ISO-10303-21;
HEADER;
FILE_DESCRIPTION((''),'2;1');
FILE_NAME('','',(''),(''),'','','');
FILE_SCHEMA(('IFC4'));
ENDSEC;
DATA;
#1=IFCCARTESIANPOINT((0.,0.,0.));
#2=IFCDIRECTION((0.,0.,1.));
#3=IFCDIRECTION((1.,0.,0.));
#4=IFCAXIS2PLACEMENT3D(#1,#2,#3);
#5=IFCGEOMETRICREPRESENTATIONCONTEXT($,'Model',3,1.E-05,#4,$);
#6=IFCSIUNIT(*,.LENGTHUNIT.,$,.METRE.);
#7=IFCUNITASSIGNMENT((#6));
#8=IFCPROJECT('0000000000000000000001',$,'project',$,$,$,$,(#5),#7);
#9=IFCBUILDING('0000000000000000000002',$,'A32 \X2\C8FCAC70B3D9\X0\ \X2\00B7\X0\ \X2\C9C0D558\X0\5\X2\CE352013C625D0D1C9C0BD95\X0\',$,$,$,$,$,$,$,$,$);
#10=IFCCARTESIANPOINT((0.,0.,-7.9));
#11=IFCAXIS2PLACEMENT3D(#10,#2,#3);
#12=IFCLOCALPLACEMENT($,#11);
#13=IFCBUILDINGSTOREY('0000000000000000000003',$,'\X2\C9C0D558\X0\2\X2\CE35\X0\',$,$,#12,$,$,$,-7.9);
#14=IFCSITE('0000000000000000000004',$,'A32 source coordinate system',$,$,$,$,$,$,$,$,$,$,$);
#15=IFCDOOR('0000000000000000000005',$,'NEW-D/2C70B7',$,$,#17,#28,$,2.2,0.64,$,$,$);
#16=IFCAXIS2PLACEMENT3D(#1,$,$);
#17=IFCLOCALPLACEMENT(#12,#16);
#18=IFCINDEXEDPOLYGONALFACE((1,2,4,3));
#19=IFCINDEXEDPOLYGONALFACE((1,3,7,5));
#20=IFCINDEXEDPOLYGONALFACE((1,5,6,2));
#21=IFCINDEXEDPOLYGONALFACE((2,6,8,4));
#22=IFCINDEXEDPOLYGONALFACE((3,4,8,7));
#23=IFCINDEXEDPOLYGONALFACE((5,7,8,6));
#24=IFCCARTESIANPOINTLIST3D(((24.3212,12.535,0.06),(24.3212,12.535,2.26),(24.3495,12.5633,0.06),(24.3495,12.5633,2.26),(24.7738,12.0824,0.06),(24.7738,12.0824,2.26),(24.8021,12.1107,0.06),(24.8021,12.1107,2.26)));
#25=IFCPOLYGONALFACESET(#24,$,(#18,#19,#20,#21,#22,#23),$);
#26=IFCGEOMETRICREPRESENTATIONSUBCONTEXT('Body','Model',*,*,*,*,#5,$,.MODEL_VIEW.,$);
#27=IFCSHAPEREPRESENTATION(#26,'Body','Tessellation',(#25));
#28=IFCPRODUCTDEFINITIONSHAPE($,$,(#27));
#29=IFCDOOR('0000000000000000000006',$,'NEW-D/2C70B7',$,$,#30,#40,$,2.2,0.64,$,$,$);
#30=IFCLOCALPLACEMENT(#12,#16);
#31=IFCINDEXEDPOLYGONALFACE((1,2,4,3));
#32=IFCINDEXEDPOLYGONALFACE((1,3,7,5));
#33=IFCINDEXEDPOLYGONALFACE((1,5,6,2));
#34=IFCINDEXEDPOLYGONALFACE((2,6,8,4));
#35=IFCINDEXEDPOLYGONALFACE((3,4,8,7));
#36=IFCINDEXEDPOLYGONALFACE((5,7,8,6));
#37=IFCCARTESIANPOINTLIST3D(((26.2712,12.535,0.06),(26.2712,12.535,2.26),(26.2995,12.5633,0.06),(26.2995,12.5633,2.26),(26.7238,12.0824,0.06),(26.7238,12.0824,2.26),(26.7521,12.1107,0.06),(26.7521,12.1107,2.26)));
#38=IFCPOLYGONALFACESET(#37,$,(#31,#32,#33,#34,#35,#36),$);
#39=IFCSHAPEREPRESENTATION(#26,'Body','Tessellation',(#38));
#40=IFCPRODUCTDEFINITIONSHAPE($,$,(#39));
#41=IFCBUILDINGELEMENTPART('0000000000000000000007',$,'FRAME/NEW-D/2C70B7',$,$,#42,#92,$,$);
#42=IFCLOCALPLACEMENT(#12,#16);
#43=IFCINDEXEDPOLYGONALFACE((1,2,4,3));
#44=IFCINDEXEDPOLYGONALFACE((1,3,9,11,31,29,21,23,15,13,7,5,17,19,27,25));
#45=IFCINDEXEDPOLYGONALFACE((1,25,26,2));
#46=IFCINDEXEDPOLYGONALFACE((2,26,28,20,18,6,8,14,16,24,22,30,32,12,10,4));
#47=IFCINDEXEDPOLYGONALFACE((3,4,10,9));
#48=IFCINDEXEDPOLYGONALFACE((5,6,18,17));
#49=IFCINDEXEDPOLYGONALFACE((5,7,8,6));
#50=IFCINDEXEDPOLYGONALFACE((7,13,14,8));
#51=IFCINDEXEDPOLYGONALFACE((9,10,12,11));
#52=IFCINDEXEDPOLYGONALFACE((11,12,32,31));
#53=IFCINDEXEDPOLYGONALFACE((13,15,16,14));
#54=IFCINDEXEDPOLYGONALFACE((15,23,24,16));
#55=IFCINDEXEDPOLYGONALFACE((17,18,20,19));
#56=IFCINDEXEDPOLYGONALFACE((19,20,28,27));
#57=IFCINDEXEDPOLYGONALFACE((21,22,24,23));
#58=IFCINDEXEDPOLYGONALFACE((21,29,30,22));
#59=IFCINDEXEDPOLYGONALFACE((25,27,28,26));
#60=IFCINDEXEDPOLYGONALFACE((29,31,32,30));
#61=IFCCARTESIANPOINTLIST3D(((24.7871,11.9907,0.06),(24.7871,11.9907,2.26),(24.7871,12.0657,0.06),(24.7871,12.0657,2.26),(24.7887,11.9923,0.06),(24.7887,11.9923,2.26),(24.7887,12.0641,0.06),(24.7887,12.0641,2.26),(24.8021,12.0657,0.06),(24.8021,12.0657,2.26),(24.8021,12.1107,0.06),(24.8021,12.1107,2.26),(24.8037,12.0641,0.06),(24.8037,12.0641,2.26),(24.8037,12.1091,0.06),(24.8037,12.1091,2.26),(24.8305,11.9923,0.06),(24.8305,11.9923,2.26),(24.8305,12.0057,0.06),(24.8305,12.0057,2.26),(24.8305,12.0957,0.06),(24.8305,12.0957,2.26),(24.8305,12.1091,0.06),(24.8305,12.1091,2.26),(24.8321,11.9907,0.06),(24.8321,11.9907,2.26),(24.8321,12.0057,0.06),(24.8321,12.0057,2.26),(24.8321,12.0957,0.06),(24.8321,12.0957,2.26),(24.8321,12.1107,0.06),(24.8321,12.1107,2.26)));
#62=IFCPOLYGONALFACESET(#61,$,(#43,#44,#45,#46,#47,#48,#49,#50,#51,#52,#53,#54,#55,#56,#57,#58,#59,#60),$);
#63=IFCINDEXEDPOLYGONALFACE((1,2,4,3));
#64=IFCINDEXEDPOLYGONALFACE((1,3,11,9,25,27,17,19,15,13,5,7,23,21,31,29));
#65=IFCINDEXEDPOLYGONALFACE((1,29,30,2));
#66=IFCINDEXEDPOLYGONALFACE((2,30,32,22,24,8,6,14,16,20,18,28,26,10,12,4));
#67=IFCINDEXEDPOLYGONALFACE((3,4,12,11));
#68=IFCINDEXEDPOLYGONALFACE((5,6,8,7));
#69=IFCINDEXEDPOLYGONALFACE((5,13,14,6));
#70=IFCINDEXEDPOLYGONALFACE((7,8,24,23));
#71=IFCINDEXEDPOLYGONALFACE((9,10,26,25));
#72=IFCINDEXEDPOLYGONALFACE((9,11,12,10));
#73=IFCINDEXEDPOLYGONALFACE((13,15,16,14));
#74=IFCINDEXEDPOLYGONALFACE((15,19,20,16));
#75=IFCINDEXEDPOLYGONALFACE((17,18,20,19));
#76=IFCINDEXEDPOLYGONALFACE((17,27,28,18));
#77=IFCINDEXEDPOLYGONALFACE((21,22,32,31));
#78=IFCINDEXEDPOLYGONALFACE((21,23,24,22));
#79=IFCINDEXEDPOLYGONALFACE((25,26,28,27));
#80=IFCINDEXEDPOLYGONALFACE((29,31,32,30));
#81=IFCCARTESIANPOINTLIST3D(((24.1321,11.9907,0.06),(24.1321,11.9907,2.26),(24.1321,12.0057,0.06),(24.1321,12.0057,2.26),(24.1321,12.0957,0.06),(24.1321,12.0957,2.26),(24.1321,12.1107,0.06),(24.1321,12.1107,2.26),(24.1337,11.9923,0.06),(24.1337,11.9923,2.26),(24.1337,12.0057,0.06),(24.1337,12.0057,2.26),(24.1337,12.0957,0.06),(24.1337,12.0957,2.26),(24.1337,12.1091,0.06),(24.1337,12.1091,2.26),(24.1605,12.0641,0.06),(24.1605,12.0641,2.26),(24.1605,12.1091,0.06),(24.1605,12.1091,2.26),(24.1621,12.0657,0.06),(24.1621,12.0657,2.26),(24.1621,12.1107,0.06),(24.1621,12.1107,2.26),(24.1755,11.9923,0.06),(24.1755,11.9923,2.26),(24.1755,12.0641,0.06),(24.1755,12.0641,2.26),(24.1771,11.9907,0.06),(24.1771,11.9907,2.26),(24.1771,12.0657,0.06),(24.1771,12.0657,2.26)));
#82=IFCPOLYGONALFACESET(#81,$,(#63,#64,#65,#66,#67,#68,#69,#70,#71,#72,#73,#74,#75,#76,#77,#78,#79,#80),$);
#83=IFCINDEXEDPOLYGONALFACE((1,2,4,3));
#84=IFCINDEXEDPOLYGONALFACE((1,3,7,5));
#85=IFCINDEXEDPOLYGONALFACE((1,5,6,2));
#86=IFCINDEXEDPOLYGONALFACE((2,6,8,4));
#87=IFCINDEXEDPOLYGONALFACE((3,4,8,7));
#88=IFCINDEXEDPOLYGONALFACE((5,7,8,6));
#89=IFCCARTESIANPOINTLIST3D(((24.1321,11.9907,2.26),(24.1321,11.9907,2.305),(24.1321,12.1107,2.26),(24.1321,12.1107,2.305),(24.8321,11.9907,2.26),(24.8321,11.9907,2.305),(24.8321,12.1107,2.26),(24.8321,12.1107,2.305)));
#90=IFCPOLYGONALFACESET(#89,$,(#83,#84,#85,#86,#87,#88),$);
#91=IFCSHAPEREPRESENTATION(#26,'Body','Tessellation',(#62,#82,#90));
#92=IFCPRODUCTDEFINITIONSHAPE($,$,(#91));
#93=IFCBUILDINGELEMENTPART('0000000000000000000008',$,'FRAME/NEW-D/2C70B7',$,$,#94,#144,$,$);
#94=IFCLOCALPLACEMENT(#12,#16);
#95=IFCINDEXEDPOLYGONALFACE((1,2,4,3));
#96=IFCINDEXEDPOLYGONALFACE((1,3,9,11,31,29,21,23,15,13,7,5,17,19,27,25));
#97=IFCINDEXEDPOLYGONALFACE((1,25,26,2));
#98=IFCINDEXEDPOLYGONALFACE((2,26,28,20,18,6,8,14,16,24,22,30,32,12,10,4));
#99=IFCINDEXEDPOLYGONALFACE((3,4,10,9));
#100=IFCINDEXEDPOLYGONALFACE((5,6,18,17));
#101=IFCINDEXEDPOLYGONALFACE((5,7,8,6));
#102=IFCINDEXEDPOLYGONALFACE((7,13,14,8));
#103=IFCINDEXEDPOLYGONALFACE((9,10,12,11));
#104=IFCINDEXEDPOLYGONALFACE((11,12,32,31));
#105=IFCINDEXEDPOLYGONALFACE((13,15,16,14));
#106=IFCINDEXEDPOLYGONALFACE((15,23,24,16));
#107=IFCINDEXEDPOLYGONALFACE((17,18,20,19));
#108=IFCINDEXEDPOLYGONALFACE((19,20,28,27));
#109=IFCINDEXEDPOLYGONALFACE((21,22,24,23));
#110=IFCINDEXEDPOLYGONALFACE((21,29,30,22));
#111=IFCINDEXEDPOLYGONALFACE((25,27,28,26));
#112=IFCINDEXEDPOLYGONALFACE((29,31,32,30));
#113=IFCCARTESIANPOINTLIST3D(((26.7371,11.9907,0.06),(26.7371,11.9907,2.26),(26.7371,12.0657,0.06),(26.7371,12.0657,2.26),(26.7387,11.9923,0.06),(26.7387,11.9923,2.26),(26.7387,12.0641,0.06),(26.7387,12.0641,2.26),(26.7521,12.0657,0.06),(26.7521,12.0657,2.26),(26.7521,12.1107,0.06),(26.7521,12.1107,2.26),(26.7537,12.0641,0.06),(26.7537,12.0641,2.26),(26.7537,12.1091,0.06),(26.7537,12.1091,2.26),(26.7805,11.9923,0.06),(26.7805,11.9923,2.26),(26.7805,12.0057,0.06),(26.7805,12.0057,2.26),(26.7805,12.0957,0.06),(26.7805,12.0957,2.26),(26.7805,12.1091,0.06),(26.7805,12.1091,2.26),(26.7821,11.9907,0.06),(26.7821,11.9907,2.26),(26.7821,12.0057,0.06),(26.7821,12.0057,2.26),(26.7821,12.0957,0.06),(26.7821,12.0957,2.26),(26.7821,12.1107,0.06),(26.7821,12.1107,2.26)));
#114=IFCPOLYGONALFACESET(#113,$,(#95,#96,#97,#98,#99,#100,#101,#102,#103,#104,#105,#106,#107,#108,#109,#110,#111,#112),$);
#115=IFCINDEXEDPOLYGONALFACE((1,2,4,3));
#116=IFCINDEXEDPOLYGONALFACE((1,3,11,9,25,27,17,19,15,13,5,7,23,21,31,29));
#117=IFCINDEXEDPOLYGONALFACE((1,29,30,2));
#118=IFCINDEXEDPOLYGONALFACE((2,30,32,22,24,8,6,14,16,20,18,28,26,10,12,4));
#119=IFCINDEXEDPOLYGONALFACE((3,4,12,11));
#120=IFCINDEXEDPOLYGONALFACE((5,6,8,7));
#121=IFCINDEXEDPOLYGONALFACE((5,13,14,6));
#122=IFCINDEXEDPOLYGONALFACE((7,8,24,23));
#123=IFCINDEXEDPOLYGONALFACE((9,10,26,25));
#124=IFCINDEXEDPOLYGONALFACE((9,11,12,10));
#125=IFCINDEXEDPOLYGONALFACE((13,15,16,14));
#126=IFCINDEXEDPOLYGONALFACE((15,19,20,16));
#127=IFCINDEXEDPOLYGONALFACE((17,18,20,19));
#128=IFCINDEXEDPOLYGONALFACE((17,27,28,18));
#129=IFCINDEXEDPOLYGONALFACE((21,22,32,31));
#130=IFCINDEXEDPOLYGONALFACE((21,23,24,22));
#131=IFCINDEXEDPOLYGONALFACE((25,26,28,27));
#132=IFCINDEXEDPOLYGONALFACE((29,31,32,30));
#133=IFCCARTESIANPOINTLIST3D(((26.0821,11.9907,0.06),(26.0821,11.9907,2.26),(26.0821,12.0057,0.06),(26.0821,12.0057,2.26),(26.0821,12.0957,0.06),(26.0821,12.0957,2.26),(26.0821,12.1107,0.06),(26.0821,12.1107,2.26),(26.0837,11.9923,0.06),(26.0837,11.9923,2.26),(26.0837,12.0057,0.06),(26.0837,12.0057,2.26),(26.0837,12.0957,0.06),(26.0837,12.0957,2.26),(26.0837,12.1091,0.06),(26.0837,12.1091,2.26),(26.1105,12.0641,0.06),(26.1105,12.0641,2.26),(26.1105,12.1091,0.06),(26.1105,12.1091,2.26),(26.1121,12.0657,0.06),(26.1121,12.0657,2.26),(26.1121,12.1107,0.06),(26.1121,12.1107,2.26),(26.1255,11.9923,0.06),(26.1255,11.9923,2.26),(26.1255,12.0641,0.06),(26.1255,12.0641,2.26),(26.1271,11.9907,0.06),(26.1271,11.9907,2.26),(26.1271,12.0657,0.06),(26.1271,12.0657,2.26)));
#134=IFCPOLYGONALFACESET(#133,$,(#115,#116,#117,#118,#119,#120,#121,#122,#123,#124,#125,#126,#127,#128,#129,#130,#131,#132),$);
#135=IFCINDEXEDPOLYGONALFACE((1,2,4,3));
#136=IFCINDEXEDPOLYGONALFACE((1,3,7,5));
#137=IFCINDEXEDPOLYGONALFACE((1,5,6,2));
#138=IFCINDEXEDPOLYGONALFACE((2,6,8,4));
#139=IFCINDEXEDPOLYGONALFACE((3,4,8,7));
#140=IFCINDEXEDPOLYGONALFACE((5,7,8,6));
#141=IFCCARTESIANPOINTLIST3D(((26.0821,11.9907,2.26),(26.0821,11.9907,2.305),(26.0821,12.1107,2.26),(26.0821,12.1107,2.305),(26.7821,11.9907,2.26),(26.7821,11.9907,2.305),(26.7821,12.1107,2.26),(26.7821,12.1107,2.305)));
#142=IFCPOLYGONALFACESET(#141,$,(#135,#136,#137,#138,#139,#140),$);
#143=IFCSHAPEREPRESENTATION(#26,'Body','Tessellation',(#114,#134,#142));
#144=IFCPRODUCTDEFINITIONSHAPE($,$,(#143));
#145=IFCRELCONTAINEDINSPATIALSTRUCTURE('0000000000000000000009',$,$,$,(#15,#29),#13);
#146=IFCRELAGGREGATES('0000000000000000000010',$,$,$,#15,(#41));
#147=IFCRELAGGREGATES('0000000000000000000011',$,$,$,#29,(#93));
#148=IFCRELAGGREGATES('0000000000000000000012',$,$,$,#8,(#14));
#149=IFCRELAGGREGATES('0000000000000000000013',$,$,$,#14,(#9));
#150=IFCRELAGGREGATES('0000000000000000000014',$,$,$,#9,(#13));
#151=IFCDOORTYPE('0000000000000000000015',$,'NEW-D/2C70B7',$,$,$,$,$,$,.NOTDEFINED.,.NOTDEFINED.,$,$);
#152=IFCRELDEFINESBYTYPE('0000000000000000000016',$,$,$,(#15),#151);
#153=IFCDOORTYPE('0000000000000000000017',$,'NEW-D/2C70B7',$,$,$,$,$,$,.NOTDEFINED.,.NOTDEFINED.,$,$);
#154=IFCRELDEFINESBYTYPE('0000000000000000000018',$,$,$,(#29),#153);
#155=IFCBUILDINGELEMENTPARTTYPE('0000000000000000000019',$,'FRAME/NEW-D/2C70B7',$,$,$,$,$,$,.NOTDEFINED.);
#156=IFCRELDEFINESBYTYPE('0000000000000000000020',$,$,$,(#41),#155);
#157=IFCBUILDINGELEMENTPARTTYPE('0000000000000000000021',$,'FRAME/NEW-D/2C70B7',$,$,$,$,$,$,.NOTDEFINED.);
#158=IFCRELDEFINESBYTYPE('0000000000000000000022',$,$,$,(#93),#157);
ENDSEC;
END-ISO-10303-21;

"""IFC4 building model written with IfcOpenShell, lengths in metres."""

from ifc_helpers import new_model, si_unit, frame, origin, origin_with_axes, place, context, subcontext, project, spatial, polyline, outline, extrude, source, transform, mapped, type_object, type_shapes, element, aggregate, save


model = new_model("IFC4")

# Units and contexts
model_context = context("Model", 3, precision=1e-05, world=origin_with_axes())
body_context = subcontext(model_context, "Body", "Model", "MODEL_VIEW")
ifc_project = project(units=[si_unit("LENGTHUNIT", "METRE")], contexts=[model_context])

# Site, building, storey
site = spatial("IfcSite", under=ifc_project, Name="A32 source coordinate system")
building = spatial("IfcBuilding", under=site, Name="A32 주거동 · 지하5층–옥탑지붕")
storey_placement = place(None, frame((0.0, 0.0, -7.9), z_axis=(0.0, 0.0, 1.0), x_axis=(1.0, 0.0, 0.0)))
storey = spatial("IfcBuildingStorey", under=building, at=storey_placement, Name="지하2층", Elevation=-7.9)

# Doors
door_type_1 = type_object("IfcDoorType", Name="NEW-D/2C70B7", OperationType="NOTDEFINED", PredefinedType="NOTDEFINED")
shared_shape_1 = source(origin(), body_context, "Body", "SweptSolid", [
    extrude(outline(polyline([(24.8021, 12.1107), (24.7738, 12.0824), (24.3212, 12.535), (24.3495, 12.5633), (24.8021, 12.1107)])), frame((0.0, 0.0, 0.06)), (0.0, 0.0, 1.0), 2.2),
])
type_shapes(door_type_1, [shared_shape_1])
door_1_placement = place(storey_placement, origin_with_axes())
door_1 = element("IfcDoor", 1, at=door_1_placement, inside=storey, type_object=door_type_1, Name="NEW-D/2C70B7", OverallHeight=2.2, OverallWidth=0.64, context=body_context, shape_type="MappedRepresentation", body=[
    mapped(shared_shape_1, transform((0.0, 0.0, 0.0), scale=1.0)),
])
door_type_2 = type_object("IfcDoorType", Name="NEW-D/2C70B7", OperationType="NOTDEFINED", PredefinedType="NOTDEFINED")
shared_shape_2 = source(origin(), body_context, "Body", "SweptSolid", [
    extrude(outline(polyline([(26.7521, 12.1107), (26.7238, 12.0824), (26.2712, 12.535), (26.2995, 12.5633), (26.7521, 12.1107)])), frame((0.0, 0.0, 0.06)), (0.0, 0.0, 1.0), 2.2),
])
type_shapes(door_type_2, [shared_shape_2])
door_2_placement = place(storey_placement, origin_with_axes())
door_2 = element("IfcDoor", 2, at=door_2_placement, inside=storey, type_object=door_type_2, Name="NEW-D/2C70B7", OverallHeight=2.2, OverallWidth=0.64, context=body_context, shape_type="MappedRepresentation", body=[
    mapped(shared_shape_2, transform((0.0, 0.0, 0.0), scale=1.0)),
])

# Building element parts
building_element_part_type_1 = type_object("IfcBuildingElementPartType", Name="FRAME/NEW-D/2C70B7", PredefinedType="NOTDEFINED")
shared_shape_3 = source(origin(), body_context, "Body", "SweptSolid", [
    extrude(outline(polyline([(24.8037, 12.1091), (24.8037, 12.0641), (24.7887, 12.0641), (24.7887, 11.9923), (24.8305, 11.9923), (24.8305, 12.0057), (24.8321, 12.0057), (24.8321, 11.9907), (24.7871, 11.9907), (24.7871, 12.0657), (24.8021, 12.0657), (24.8021, 12.1107), (24.8321, 12.1107), (24.8321, 12.0957), (24.8305, 12.0957), (24.8305, 12.1091), (24.8037, 12.1091)])), frame((0.0, 0.0, 0.06)), (0.0, 0.0, 1.0), 2.2),
    extrude(outline(polyline([(24.1321, 12.1107), (24.1621, 12.1107), (24.1621, 12.0657), (24.1771, 12.0657), (24.1771, 11.9907), (24.1321, 11.9907), (24.1321, 12.0057), (24.1337, 12.0057), (24.1337, 11.9923), (24.1755, 11.9923), (24.1755, 12.0641), (24.1605, 12.0641), (24.1605, 12.1091), (24.1337, 12.1091), (24.1337, 12.0957), (24.1321, 12.0957), (24.1321, 12.1107)])), frame((0.0, 0.0, 0.06)), (0.0, 0.0, 1.0), 2.2),
    extrude(outline(polyline([(24.8321, 11.9907), (24.8321, 12.1107), (24.1321, 12.1107), (24.1321, 11.9907), (24.8321, 11.9907)])), frame((0.0, 0.0, 2.26)), (0.0, 0.0, 1.0), 0.045),
])
type_shapes(building_element_part_type_1, [shared_shape_3])
building_element_part_1_placement = place(door_1_placement, origin_with_axes())
building_element_part_1 = element("IfcBuildingElementPart", 3, at=building_element_part_1_placement, type_object=building_element_part_type_1, Name="FRAME/NEW-D/2C70B7", context=body_context, shape_type="MappedRepresentation", body=[
    mapped(shared_shape_3, transform((0.0, 0.0, 0.0), scale=1.0)),
])
aggregate(door_1, [building_element_part_1])
building_element_part_type_2 = type_object("IfcBuildingElementPartType", Name="FRAME/NEW-D/2C70B7", PredefinedType="NOTDEFINED")
shared_shape_4 = source(origin(), body_context, "Body", "SweptSolid", [
    extrude(outline(polyline([(26.7537, 12.1091), (26.7537, 12.0641), (26.7387, 12.0641), (26.7387, 11.9923), (26.7805, 11.9923), (26.7805, 12.0057), (26.7821, 12.0057), (26.7821, 11.9907), (26.7371, 11.9907), (26.7371, 12.0657), (26.7521, 12.0657), (26.7521, 12.1107), (26.7821, 12.1107), (26.7821, 12.0957), (26.7805, 12.0957), (26.7805, 12.1091), (26.7537, 12.1091)])), frame((0.0, 0.0, 0.06)), (0.0, 0.0, 1.0), 2.2),
    extrude(outline(polyline([(26.0821, 12.1107), (26.1121, 12.1107), (26.1121, 12.0657), (26.1271, 12.0657), (26.1271, 11.9907), (26.0821, 11.9907), (26.0821, 12.0057), (26.0837, 12.0057), (26.0837, 11.9923), (26.1255, 11.9923), (26.1255, 12.0641), (26.1105, 12.0641), (26.1105, 12.1091), (26.0837, 12.1091), (26.0837, 12.0957), (26.0821, 12.0957), (26.0821, 12.1107)])), frame((0.0, 0.0, 0.06)), (0.0, 0.0, 1.0), 2.2),
    extrude(outline(polyline([(26.7821, 11.9907), (26.7821, 12.1107), (26.0821, 12.1107), (26.0821, 11.9907), (26.7821, 11.9907)])), frame((0.0, 0.0, 2.26)), (0.0, 0.0, 1.0), 0.045),
])
type_shapes(building_element_part_type_2, [shared_shape_4])
building_element_part_2_placement = place(door_2_placement, origin_with_axes())
building_element_part_2 = element("IfcBuildingElementPart", 4, at=building_element_part_2_placement, type_object=building_element_part_type_2, Name="FRAME/NEW-D/2C70B7", context=body_context, shape_type="MappedRepresentation", body=[
    mapped(shared_shape_4, transform((0.0, 0.0, 0.0), scale=1.0)),
])
aggregate(door_2, [building_element_part_2])

save(model, "model.ifc")
